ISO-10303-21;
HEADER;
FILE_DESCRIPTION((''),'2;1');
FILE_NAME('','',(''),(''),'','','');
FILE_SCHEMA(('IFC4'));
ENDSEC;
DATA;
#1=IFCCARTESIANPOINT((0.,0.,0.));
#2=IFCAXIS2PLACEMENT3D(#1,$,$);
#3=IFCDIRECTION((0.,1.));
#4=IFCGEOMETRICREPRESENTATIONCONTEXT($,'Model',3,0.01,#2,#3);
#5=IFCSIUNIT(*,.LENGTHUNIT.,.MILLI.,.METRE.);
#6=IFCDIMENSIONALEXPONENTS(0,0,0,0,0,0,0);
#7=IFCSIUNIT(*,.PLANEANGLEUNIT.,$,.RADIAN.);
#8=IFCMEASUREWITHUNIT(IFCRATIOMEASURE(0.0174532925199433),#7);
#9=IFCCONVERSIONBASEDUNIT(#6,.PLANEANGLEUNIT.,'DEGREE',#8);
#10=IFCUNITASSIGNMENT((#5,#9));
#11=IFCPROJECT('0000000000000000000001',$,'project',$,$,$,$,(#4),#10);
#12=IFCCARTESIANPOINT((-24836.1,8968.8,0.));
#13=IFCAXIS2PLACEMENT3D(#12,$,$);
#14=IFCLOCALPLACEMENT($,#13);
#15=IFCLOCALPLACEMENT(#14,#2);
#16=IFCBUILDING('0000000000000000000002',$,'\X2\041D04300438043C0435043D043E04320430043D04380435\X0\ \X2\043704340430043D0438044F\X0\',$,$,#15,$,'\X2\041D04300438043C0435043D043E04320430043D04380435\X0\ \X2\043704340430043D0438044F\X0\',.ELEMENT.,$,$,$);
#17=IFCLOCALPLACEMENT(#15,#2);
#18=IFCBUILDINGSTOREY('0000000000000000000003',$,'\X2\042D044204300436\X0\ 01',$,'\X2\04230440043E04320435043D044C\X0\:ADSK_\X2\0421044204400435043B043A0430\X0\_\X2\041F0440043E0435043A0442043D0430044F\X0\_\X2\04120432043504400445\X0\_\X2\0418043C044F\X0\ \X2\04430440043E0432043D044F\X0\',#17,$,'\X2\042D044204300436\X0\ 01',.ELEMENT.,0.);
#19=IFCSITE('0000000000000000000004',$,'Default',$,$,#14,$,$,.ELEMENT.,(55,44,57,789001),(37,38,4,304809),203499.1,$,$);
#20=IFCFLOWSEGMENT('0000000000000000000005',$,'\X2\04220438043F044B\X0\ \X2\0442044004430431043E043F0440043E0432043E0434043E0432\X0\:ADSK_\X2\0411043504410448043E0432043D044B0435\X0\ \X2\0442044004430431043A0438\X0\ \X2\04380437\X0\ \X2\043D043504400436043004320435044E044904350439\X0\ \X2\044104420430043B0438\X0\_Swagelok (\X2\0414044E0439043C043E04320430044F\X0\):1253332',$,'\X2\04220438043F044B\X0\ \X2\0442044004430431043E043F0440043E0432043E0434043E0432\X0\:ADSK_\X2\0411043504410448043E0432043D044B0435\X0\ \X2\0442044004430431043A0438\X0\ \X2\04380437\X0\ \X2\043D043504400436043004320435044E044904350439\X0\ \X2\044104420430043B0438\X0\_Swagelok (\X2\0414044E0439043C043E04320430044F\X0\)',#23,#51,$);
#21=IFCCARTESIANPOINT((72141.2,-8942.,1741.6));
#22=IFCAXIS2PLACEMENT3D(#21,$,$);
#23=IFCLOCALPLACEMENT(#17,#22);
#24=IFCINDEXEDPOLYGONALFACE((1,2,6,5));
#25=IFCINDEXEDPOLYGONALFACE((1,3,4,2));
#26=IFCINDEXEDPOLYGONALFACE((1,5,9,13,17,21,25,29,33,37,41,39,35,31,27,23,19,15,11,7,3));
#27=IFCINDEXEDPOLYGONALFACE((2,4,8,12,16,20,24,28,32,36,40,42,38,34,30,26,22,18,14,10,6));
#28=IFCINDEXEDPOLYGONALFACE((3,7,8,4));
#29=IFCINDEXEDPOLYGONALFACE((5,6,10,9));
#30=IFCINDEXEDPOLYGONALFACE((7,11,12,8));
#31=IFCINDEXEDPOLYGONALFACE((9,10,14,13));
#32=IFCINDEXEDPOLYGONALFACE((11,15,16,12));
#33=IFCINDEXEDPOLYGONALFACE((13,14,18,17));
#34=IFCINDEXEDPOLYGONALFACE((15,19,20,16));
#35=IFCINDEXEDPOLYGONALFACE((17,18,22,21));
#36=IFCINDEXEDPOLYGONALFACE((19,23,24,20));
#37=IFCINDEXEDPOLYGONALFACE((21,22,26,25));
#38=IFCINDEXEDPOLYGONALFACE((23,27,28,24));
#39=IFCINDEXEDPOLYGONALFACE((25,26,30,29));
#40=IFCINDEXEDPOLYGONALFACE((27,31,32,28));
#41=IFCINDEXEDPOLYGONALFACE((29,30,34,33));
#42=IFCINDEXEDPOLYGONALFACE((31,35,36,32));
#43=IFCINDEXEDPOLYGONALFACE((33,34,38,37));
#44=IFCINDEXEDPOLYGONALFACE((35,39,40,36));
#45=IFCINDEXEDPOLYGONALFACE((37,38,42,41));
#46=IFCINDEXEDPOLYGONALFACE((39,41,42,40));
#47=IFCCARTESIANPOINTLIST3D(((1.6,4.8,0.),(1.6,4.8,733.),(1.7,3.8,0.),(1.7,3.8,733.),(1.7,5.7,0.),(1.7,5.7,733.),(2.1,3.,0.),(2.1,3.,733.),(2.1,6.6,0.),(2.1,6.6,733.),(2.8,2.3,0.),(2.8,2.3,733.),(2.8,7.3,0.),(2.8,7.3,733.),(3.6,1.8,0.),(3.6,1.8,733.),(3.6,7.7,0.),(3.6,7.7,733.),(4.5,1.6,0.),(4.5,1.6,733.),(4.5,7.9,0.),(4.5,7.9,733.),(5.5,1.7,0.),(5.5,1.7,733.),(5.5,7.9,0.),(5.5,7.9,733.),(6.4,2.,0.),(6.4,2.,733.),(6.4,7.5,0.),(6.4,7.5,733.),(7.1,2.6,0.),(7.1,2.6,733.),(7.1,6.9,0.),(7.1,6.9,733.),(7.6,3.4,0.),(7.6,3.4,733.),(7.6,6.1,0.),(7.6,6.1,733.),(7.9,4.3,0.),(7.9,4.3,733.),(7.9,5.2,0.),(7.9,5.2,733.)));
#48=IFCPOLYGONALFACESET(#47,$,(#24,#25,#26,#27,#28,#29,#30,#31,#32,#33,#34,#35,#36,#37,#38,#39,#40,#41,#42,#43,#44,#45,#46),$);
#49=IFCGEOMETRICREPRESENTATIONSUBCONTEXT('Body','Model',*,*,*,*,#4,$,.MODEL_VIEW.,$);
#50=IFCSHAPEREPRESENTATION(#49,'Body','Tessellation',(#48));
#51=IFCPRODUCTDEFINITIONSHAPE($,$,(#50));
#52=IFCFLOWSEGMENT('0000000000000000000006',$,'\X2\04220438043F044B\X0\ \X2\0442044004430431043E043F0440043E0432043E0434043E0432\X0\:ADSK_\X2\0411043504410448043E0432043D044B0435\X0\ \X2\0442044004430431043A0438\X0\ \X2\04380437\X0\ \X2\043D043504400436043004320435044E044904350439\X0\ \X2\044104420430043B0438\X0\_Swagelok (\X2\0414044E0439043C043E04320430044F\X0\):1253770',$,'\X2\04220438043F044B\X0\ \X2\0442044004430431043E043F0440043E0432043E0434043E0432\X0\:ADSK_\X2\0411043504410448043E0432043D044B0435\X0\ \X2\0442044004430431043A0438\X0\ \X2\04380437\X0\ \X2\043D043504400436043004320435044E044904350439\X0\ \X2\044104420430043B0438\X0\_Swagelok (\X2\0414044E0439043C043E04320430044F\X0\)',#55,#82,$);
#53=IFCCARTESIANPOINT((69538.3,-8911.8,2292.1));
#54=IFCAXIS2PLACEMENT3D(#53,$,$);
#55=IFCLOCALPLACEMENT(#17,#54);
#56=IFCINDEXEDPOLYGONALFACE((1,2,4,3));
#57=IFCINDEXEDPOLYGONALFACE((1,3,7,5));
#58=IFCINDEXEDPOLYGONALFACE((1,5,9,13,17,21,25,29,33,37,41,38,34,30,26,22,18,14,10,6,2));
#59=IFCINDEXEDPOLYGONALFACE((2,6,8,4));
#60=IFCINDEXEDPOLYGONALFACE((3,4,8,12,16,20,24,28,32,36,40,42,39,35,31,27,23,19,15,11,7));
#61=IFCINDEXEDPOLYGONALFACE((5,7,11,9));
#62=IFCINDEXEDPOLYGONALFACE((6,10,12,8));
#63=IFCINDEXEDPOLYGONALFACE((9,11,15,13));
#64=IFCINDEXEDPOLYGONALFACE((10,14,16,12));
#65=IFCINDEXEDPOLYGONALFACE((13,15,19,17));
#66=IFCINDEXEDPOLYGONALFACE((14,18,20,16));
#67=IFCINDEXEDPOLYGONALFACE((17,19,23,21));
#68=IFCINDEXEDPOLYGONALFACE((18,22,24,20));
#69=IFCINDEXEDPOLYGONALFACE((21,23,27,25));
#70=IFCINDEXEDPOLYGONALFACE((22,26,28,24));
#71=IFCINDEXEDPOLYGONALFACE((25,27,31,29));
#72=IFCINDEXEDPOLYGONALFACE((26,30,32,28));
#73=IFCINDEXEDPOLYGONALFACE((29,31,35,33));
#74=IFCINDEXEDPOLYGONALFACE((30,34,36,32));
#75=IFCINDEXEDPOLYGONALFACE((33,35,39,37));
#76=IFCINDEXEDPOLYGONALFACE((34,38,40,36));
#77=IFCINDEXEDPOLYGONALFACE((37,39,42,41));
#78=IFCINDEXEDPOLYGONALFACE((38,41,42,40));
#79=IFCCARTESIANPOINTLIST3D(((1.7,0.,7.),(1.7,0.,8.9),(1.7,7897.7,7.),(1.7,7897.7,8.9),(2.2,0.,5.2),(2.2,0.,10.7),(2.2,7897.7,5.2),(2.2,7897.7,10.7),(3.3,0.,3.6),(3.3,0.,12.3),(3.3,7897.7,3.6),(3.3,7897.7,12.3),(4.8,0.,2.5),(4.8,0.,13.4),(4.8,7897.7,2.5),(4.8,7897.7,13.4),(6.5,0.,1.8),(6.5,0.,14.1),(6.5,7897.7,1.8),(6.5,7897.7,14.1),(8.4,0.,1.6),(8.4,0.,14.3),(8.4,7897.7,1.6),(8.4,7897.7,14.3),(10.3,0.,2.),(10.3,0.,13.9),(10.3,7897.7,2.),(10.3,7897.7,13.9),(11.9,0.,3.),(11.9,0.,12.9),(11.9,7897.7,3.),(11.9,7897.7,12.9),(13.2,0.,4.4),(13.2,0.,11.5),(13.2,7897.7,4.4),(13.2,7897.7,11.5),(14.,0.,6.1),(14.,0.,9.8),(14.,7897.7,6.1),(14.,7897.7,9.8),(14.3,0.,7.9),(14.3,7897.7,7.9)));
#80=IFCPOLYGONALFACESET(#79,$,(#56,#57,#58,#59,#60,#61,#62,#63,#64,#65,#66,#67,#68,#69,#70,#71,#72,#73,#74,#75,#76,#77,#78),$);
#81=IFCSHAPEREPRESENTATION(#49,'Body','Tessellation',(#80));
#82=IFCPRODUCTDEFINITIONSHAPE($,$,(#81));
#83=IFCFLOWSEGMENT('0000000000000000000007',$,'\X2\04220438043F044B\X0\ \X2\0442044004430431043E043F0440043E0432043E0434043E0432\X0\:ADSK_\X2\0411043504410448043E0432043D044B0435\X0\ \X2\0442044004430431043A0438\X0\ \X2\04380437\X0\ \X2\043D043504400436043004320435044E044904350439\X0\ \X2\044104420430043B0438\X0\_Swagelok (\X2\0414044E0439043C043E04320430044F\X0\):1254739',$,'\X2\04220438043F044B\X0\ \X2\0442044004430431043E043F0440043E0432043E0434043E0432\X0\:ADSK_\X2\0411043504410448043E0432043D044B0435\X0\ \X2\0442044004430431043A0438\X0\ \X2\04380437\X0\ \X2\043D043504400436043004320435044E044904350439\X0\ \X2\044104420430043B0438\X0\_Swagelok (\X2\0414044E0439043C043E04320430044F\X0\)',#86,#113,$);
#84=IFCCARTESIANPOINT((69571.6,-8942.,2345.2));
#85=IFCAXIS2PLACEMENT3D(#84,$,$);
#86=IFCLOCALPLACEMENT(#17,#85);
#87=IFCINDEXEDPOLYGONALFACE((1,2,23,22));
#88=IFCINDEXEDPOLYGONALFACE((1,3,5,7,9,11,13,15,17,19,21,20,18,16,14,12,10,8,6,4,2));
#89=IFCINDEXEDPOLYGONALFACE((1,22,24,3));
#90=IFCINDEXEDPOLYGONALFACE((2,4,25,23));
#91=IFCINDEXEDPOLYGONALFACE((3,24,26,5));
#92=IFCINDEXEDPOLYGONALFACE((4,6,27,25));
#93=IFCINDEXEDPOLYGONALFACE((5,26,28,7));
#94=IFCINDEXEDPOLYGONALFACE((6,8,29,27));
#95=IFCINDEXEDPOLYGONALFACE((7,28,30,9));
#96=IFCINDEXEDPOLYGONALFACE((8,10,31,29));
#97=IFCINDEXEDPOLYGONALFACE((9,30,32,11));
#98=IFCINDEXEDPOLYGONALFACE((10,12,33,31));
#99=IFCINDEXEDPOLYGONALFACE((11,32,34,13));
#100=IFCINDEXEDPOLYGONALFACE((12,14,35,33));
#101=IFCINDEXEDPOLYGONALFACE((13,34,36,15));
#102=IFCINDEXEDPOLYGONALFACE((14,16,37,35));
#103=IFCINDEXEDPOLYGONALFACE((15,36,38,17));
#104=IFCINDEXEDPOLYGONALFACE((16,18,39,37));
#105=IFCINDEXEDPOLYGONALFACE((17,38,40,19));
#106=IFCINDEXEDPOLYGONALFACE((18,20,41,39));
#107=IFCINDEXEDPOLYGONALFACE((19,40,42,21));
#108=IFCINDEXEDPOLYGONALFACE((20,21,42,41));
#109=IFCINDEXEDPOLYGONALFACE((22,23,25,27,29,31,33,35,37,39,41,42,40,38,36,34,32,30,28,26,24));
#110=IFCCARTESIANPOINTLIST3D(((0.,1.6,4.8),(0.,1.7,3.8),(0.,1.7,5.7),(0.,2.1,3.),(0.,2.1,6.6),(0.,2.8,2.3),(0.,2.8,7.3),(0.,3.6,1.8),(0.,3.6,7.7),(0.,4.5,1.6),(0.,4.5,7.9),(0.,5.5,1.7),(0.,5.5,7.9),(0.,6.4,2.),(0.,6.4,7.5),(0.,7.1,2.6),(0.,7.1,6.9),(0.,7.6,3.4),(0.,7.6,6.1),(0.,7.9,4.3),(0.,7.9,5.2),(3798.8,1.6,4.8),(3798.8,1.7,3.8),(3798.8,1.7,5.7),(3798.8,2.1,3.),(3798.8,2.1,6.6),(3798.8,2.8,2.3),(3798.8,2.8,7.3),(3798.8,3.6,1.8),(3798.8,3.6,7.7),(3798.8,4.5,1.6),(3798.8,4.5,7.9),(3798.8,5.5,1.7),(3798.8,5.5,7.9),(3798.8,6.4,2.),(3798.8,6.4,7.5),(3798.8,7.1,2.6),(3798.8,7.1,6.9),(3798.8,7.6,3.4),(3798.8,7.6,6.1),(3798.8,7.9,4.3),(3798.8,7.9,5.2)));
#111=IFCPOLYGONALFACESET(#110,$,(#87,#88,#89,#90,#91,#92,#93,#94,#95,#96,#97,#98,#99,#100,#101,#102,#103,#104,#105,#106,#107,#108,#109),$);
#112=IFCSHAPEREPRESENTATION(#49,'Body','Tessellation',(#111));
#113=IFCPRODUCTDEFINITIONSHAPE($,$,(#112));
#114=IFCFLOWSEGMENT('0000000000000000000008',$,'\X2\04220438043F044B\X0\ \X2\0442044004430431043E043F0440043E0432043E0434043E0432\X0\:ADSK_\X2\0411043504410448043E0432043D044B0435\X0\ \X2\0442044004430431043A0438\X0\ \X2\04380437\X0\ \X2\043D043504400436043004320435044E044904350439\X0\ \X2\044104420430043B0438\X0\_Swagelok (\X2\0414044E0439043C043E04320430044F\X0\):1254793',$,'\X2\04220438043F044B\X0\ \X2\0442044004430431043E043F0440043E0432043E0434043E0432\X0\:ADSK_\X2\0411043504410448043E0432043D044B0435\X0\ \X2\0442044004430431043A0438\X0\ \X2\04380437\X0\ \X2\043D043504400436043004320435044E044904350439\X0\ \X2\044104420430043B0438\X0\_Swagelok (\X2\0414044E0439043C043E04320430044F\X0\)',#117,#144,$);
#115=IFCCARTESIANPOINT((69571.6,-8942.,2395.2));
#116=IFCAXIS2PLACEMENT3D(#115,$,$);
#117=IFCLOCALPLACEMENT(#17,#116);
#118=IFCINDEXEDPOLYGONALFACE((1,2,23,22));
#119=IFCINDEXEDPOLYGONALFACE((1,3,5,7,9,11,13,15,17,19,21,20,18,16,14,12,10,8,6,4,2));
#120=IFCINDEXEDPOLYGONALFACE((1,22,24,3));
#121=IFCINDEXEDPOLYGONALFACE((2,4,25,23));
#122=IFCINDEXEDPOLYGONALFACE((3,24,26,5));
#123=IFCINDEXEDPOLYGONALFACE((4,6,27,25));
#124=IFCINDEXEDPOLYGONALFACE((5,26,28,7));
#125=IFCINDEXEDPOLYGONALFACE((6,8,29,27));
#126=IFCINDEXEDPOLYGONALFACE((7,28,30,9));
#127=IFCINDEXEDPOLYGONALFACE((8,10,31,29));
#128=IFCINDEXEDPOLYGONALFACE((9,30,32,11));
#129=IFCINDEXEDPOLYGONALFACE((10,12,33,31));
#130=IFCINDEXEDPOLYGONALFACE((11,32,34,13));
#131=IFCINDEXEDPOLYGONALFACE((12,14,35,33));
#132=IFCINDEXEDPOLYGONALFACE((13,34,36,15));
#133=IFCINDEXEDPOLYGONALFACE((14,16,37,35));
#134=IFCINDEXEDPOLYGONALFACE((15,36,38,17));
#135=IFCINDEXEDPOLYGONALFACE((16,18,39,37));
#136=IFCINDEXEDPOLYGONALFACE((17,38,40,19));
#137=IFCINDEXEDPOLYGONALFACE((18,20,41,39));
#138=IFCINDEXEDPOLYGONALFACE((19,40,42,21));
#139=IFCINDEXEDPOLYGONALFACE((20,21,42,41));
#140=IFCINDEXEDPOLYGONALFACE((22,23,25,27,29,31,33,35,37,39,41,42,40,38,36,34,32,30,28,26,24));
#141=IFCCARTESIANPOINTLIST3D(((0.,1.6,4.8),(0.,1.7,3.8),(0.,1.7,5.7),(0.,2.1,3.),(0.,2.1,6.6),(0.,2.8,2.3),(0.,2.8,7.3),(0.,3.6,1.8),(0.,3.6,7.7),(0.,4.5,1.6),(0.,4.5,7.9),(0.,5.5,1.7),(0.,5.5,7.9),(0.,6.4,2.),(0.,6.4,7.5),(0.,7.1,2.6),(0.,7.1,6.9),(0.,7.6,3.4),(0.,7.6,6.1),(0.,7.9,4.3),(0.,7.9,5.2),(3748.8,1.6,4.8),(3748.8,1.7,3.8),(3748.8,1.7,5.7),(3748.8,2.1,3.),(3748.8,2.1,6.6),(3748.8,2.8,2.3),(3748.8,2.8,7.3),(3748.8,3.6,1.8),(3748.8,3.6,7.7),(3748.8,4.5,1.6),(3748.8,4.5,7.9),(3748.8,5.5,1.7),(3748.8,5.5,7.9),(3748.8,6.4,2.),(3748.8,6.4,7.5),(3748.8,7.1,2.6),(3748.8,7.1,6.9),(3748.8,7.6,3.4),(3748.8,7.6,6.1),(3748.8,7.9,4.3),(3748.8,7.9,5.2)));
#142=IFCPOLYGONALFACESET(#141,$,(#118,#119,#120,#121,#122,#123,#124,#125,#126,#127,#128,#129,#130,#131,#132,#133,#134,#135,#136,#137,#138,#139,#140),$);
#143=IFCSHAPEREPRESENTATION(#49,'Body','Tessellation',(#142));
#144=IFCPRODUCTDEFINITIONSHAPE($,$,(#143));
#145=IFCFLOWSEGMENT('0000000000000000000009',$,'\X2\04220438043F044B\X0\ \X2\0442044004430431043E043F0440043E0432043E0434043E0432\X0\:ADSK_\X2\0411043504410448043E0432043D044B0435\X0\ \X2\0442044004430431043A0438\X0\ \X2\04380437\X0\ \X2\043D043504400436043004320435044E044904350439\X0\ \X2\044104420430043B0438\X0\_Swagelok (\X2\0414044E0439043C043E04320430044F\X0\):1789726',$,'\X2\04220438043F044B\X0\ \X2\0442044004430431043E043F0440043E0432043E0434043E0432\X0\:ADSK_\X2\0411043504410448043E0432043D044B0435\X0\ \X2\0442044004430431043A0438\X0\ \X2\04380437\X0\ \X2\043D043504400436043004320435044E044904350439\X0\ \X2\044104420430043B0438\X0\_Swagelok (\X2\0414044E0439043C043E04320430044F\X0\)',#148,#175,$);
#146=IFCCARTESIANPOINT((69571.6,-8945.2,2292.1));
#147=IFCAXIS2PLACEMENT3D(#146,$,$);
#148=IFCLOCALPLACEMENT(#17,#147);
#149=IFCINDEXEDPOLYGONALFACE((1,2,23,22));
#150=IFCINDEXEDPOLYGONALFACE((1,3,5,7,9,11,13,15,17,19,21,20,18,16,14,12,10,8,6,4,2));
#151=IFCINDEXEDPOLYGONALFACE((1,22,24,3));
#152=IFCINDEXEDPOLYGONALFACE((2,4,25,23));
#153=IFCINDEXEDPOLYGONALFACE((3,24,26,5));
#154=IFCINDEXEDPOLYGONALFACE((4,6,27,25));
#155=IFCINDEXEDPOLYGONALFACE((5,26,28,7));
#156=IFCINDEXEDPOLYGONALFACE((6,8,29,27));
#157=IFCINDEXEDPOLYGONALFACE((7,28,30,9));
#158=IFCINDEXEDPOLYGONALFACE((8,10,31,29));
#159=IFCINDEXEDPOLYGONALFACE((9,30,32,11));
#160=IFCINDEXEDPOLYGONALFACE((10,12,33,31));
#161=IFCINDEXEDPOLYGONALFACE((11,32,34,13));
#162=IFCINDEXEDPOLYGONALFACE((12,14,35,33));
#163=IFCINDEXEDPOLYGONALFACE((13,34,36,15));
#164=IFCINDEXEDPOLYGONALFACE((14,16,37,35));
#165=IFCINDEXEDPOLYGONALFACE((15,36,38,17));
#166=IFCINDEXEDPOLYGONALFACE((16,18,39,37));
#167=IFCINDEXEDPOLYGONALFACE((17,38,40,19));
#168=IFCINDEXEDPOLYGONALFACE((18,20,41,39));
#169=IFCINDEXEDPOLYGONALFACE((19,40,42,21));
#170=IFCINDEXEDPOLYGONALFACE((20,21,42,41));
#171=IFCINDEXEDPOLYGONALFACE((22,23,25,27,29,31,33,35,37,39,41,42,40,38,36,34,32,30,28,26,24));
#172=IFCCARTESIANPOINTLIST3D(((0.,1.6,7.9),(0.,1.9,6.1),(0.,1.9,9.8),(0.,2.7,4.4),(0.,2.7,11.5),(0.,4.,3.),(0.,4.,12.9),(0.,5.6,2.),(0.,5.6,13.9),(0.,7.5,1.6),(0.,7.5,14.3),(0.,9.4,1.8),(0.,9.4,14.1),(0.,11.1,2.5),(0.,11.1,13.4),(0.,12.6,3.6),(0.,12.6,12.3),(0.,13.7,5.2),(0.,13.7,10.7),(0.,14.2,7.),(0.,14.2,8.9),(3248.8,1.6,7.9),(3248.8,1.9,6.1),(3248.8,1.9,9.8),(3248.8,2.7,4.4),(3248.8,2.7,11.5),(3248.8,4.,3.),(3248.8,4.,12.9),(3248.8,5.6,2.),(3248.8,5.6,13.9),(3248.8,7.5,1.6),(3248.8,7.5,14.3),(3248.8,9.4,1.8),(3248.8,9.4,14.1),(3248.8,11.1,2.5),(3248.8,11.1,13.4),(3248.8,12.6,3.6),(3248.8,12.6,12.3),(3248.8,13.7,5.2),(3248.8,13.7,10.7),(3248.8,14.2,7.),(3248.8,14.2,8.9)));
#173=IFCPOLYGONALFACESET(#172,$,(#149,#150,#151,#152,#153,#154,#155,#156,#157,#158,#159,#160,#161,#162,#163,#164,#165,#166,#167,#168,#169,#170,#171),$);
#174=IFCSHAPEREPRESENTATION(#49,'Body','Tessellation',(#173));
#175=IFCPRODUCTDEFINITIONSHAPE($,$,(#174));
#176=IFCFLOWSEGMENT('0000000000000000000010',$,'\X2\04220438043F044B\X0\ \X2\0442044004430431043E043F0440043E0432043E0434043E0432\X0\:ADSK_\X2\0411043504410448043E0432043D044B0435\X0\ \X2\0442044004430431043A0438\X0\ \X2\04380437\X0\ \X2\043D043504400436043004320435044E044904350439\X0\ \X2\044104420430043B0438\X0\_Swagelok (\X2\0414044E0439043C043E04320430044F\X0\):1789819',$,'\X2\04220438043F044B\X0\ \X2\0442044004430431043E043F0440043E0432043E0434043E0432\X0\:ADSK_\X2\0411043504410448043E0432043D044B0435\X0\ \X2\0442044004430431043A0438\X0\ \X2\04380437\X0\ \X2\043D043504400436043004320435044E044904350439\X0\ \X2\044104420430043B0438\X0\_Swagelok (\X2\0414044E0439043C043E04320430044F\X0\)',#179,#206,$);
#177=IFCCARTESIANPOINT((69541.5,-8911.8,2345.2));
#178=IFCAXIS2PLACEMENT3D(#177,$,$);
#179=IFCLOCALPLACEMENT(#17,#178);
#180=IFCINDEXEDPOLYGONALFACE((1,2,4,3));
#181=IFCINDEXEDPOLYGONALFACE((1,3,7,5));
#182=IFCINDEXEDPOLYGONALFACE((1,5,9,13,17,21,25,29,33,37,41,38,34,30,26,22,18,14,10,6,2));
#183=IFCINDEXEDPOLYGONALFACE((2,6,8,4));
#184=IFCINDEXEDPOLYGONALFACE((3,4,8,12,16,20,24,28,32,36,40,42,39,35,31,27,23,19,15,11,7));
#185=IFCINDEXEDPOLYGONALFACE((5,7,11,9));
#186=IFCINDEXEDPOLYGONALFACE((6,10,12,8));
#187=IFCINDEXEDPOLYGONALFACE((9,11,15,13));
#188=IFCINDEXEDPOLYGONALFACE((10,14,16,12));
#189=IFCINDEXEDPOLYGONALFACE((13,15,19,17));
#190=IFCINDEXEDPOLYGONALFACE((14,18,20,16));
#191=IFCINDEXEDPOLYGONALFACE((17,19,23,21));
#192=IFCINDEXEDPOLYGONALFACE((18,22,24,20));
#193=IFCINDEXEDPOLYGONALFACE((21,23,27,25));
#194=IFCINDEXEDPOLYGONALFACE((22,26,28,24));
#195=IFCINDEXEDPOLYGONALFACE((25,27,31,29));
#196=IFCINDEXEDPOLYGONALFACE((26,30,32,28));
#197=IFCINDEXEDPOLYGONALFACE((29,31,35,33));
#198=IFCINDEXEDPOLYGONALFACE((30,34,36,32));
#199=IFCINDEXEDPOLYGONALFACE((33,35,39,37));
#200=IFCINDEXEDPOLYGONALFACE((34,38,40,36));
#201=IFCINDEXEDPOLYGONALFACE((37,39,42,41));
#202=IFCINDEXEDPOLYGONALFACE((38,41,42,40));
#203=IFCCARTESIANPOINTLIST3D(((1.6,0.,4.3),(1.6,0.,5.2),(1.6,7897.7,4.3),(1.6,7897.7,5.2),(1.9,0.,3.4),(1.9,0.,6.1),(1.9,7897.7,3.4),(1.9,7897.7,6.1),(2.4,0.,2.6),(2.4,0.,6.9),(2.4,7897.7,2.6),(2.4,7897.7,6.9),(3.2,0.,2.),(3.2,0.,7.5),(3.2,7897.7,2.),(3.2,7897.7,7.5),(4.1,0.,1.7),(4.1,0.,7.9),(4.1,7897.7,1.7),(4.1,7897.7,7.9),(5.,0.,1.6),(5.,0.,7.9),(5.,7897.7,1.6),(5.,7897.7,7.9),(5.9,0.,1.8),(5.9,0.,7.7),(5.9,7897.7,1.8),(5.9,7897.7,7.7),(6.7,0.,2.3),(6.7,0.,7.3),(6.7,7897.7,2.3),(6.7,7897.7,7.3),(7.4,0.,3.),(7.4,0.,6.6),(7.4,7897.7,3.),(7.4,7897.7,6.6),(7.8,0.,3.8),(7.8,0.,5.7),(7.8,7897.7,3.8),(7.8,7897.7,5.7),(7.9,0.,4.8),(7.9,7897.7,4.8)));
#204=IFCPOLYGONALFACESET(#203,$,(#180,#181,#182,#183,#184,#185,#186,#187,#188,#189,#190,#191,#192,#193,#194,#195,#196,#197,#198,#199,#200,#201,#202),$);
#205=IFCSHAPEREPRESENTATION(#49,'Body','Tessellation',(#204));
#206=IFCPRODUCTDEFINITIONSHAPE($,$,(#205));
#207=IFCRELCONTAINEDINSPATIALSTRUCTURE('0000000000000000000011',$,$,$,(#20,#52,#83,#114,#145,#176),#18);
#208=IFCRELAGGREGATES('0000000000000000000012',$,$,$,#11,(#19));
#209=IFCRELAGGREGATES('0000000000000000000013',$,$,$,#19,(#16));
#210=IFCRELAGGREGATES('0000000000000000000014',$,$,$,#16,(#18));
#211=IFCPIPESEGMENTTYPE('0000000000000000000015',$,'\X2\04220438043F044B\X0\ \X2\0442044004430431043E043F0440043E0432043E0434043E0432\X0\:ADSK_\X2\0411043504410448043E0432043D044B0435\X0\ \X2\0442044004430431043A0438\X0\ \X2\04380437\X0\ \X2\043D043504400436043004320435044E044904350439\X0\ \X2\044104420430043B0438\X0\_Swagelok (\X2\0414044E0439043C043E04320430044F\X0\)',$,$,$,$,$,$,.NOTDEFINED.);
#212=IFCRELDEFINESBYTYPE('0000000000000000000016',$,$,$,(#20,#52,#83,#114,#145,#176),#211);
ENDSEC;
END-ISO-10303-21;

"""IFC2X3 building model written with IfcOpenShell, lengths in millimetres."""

from ifc_helpers import new_model, entity, si_unit, converted_unit, direction, frame, origin, origin_2d_with_axis, place, context, subcontext, project, spatial, circle, extrude, type_object, element, save


model = new_model("IFC2X3")

# Units and contexts
model_context = context("Model", 3, precision=0.01, world=origin(), true_north=direction((0.0, 1.0)))
body_context = subcontext(model_context, "Body", "Model", "MODEL_VIEW")
ifc_project = project(units=[si_unit("LENGTHUNIT", "METRE", prefix="MILLI"), converted_unit("PLANEANGLEUNIT", "DEGREE", entity("IfcRatioMeasure", 0.0174532925199433), si_unit("PLANEANGLEUNIT", "RADIAN"), dimensions=[0, 0, 0, 0, 0, 0, 0])], contexts=[model_context])

# Site, building, storey
site_placement = place(None, frame((-24836.1, 8968.8, 0.0)))
site = spatial("IfcSite", under=ifc_project, at=site_placement, Name="Default", CompositionType="ELEMENT", RefLatitude=(55, 44, 57, 789001), RefLongitude=(37, 38, 4, 304809), RefElevation=203499.1)
building_placement = place(site_placement, origin())
building = spatial("IfcBuilding", under=site, at=building_placement, Name="Наименование здания", LongName="Наименование здания", CompositionType="ELEMENT")
storey_placement = place(building_placement, origin())
storey = spatial("IfcBuildingStorey", under=building, at=storey_placement, Name="Этаж 01", ObjectType="Уровень:ADSK_Стрелка_Проектная_Вверх_Имя уровня", LongName="Этаж 01", CompositionType="ELEMENT", Elevation=0.0)

# Flow segments
pipe_segment_type_1 = type_object("IfcPipeSegmentType", Name="Типы трубопроводов:ADSK_Бесшовные трубки из нержавеющей стали_Swagelok (Дюймовая)", PredefinedType="NOTDEFINED")
flow_segment_1_placement = place(storey_placement, frame((72141.2, -8942.0, 1741.6)))
element("IfcFlowSegment", 1, at=flow_segment_1_placement, inside=storey, type_object=pipe_segment_type_1, Name="Типы трубопроводов:ADSK_Бесшовные трубки из нержавеющей стали_Swagelok (Дюймовая):1253332", ObjectType="Типы трубопроводов:ADSK_Бесшовные трубки из нержавеющей стали_Swagelok (Дюймовая)", context=body_context, shape_type="SweptSolid", body=[
    extrude(circle(Radius=3.2, at=origin_2d_with_axis()), frame((4.8, 4.8, 0.0), z_axis=(0.0, 0.0, 1.0), x_axis=(-1.0, 0.0, 0.0)), (0.0, 0.0, 1.0), 733.0),
])
flow_segment_2_placement = place(storey_placement, frame((69538.3, -8911.8, 2292.1)))
element("IfcFlowSegment", 2, at=flow_segment_2_placement, inside=storey, type_object=pipe_segment_type_1, Name="Типы трубопроводов:ADSK_Бесшовные трубки из нержавеющей стали_Swagelok (Дюймовая):1253770", ObjectType="Типы трубопроводов:ADSK_Бесшовные трубки из нержавеющей стали_Swagelok (Дюймовая)", context=body_context, shape_type="SweptSolid", body=[
    extrude(circle(Radius=6.3, at=origin_2d_with_axis()), frame((8.0, 0.0, 8.0), z_axis=(0.0, 1.0, 0.0), x_axis=(1.0, 0.0, 0.0)), (0.0, 0.0, 1.0), 7897.7),
])
flow_segment_3_placement = place(storey_placement, frame((69571.6, -8942.0, 2345.2)))
element("IfcFlowSegment", 3, at=flow_segment_3_placement, inside=storey, type_object=pipe_segment_type_1, Name="Типы трубопроводов:ADSK_Бесшовные трубки из нержавеющей стали_Swagelok (Дюймовая):1254739", ObjectType="Типы трубопроводов:ADSK_Бесшовные трубки из нержавеющей стали_Swagelok (Дюймовая)", context=body_context, shape_type="SweptSolid", body=[
    extrude(circle(Radius=3.2, at=origin_2d_with_axis()), frame((0.0, 4.8, 4.8), z_axis=(1.0, 0.0, 0.0), x_axis=(0.0, -1.0, 0.0)), (0.0, 0.0, 1.0), 3798.8),
])
flow_segment_4_placement = place(storey_placement, frame((69571.6, -8942.0, 2395.2)))
element("IfcFlowSegment", 4, at=flow_segment_4_placement, inside=storey, type_object=pipe_segment_type_1, Name="Типы трубопроводов:ADSK_Бесшовные трубки из нержавеющей стали_Swagelok (Дюймовая):1254793", ObjectType="Типы трубопроводов:ADSK_Бесшовные трубки из нержавеющей стали_Swagelok (Дюймовая)", context=body_context, shape_type="SweptSolid", body=[
    extrude(circle(Radius=3.2, at=origin_2d_with_axis()), frame((0.0, 4.8, 4.8), z_axis=(1.0, 0.0, 0.0), x_axis=(0.0, -1.0, 0.0)), (0.0, 0.0, 1.0), 3748.8),
])
flow_segment_5_placement = place(storey_placement, frame((69571.6, -8945.2, 2292.1)))
element("IfcFlowSegment", 5, at=flow_segment_5_placement, inside=storey, type_object=pipe_segment_type_1, Name="Типы трубопроводов:ADSK_Бесшовные трубки из нержавеющей стали_Swagelok (Дюймовая):1789726", ObjectType="Типы трубопроводов:ADSK_Бесшовные трубки из нержавеющей стали_Swagelok (Дюймовая)", context=body_context, shape_type="SweptSolid", body=[
    extrude(circle(Radius=6.3, at=origin_2d_with_axis()), frame((0.0, 8.0, 8.0), z_axis=(1.0, 0.0, 0.0), x_axis=(0.0, -1.0, 0.0)), (0.0, 0.0, 1.0), 3248.8),
])
flow_segment_6_placement = place(storey_placement, frame((69541.5, -8911.8, 2345.2)))
element("IfcFlowSegment", 6, at=flow_segment_6_placement, inside=storey, type_object=pipe_segment_type_1, Name="Типы трубопроводов:ADSK_Бесшовные трубки из нержавеющей стали_Swagelok (Дюймовая):1789819", ObjectType="Типы трубопроводов:ADSK_Бесшовные трубки из нержавеющей стали_Swagelok (Дюймовая)", context=body_context, shape_type="SweptSolid", body=[
    extrude(circle(Radius=3.2, at=origin_2d_with_axis()), frame((4.8, 0.0, 4.8), z_axis=(0.0, 1.0, 0.0), x_axis=(1.0, 0.0, 0.0)), (0.0, 0.0, 1.0), 7897.7),
])

save(model, "model.ifc")
